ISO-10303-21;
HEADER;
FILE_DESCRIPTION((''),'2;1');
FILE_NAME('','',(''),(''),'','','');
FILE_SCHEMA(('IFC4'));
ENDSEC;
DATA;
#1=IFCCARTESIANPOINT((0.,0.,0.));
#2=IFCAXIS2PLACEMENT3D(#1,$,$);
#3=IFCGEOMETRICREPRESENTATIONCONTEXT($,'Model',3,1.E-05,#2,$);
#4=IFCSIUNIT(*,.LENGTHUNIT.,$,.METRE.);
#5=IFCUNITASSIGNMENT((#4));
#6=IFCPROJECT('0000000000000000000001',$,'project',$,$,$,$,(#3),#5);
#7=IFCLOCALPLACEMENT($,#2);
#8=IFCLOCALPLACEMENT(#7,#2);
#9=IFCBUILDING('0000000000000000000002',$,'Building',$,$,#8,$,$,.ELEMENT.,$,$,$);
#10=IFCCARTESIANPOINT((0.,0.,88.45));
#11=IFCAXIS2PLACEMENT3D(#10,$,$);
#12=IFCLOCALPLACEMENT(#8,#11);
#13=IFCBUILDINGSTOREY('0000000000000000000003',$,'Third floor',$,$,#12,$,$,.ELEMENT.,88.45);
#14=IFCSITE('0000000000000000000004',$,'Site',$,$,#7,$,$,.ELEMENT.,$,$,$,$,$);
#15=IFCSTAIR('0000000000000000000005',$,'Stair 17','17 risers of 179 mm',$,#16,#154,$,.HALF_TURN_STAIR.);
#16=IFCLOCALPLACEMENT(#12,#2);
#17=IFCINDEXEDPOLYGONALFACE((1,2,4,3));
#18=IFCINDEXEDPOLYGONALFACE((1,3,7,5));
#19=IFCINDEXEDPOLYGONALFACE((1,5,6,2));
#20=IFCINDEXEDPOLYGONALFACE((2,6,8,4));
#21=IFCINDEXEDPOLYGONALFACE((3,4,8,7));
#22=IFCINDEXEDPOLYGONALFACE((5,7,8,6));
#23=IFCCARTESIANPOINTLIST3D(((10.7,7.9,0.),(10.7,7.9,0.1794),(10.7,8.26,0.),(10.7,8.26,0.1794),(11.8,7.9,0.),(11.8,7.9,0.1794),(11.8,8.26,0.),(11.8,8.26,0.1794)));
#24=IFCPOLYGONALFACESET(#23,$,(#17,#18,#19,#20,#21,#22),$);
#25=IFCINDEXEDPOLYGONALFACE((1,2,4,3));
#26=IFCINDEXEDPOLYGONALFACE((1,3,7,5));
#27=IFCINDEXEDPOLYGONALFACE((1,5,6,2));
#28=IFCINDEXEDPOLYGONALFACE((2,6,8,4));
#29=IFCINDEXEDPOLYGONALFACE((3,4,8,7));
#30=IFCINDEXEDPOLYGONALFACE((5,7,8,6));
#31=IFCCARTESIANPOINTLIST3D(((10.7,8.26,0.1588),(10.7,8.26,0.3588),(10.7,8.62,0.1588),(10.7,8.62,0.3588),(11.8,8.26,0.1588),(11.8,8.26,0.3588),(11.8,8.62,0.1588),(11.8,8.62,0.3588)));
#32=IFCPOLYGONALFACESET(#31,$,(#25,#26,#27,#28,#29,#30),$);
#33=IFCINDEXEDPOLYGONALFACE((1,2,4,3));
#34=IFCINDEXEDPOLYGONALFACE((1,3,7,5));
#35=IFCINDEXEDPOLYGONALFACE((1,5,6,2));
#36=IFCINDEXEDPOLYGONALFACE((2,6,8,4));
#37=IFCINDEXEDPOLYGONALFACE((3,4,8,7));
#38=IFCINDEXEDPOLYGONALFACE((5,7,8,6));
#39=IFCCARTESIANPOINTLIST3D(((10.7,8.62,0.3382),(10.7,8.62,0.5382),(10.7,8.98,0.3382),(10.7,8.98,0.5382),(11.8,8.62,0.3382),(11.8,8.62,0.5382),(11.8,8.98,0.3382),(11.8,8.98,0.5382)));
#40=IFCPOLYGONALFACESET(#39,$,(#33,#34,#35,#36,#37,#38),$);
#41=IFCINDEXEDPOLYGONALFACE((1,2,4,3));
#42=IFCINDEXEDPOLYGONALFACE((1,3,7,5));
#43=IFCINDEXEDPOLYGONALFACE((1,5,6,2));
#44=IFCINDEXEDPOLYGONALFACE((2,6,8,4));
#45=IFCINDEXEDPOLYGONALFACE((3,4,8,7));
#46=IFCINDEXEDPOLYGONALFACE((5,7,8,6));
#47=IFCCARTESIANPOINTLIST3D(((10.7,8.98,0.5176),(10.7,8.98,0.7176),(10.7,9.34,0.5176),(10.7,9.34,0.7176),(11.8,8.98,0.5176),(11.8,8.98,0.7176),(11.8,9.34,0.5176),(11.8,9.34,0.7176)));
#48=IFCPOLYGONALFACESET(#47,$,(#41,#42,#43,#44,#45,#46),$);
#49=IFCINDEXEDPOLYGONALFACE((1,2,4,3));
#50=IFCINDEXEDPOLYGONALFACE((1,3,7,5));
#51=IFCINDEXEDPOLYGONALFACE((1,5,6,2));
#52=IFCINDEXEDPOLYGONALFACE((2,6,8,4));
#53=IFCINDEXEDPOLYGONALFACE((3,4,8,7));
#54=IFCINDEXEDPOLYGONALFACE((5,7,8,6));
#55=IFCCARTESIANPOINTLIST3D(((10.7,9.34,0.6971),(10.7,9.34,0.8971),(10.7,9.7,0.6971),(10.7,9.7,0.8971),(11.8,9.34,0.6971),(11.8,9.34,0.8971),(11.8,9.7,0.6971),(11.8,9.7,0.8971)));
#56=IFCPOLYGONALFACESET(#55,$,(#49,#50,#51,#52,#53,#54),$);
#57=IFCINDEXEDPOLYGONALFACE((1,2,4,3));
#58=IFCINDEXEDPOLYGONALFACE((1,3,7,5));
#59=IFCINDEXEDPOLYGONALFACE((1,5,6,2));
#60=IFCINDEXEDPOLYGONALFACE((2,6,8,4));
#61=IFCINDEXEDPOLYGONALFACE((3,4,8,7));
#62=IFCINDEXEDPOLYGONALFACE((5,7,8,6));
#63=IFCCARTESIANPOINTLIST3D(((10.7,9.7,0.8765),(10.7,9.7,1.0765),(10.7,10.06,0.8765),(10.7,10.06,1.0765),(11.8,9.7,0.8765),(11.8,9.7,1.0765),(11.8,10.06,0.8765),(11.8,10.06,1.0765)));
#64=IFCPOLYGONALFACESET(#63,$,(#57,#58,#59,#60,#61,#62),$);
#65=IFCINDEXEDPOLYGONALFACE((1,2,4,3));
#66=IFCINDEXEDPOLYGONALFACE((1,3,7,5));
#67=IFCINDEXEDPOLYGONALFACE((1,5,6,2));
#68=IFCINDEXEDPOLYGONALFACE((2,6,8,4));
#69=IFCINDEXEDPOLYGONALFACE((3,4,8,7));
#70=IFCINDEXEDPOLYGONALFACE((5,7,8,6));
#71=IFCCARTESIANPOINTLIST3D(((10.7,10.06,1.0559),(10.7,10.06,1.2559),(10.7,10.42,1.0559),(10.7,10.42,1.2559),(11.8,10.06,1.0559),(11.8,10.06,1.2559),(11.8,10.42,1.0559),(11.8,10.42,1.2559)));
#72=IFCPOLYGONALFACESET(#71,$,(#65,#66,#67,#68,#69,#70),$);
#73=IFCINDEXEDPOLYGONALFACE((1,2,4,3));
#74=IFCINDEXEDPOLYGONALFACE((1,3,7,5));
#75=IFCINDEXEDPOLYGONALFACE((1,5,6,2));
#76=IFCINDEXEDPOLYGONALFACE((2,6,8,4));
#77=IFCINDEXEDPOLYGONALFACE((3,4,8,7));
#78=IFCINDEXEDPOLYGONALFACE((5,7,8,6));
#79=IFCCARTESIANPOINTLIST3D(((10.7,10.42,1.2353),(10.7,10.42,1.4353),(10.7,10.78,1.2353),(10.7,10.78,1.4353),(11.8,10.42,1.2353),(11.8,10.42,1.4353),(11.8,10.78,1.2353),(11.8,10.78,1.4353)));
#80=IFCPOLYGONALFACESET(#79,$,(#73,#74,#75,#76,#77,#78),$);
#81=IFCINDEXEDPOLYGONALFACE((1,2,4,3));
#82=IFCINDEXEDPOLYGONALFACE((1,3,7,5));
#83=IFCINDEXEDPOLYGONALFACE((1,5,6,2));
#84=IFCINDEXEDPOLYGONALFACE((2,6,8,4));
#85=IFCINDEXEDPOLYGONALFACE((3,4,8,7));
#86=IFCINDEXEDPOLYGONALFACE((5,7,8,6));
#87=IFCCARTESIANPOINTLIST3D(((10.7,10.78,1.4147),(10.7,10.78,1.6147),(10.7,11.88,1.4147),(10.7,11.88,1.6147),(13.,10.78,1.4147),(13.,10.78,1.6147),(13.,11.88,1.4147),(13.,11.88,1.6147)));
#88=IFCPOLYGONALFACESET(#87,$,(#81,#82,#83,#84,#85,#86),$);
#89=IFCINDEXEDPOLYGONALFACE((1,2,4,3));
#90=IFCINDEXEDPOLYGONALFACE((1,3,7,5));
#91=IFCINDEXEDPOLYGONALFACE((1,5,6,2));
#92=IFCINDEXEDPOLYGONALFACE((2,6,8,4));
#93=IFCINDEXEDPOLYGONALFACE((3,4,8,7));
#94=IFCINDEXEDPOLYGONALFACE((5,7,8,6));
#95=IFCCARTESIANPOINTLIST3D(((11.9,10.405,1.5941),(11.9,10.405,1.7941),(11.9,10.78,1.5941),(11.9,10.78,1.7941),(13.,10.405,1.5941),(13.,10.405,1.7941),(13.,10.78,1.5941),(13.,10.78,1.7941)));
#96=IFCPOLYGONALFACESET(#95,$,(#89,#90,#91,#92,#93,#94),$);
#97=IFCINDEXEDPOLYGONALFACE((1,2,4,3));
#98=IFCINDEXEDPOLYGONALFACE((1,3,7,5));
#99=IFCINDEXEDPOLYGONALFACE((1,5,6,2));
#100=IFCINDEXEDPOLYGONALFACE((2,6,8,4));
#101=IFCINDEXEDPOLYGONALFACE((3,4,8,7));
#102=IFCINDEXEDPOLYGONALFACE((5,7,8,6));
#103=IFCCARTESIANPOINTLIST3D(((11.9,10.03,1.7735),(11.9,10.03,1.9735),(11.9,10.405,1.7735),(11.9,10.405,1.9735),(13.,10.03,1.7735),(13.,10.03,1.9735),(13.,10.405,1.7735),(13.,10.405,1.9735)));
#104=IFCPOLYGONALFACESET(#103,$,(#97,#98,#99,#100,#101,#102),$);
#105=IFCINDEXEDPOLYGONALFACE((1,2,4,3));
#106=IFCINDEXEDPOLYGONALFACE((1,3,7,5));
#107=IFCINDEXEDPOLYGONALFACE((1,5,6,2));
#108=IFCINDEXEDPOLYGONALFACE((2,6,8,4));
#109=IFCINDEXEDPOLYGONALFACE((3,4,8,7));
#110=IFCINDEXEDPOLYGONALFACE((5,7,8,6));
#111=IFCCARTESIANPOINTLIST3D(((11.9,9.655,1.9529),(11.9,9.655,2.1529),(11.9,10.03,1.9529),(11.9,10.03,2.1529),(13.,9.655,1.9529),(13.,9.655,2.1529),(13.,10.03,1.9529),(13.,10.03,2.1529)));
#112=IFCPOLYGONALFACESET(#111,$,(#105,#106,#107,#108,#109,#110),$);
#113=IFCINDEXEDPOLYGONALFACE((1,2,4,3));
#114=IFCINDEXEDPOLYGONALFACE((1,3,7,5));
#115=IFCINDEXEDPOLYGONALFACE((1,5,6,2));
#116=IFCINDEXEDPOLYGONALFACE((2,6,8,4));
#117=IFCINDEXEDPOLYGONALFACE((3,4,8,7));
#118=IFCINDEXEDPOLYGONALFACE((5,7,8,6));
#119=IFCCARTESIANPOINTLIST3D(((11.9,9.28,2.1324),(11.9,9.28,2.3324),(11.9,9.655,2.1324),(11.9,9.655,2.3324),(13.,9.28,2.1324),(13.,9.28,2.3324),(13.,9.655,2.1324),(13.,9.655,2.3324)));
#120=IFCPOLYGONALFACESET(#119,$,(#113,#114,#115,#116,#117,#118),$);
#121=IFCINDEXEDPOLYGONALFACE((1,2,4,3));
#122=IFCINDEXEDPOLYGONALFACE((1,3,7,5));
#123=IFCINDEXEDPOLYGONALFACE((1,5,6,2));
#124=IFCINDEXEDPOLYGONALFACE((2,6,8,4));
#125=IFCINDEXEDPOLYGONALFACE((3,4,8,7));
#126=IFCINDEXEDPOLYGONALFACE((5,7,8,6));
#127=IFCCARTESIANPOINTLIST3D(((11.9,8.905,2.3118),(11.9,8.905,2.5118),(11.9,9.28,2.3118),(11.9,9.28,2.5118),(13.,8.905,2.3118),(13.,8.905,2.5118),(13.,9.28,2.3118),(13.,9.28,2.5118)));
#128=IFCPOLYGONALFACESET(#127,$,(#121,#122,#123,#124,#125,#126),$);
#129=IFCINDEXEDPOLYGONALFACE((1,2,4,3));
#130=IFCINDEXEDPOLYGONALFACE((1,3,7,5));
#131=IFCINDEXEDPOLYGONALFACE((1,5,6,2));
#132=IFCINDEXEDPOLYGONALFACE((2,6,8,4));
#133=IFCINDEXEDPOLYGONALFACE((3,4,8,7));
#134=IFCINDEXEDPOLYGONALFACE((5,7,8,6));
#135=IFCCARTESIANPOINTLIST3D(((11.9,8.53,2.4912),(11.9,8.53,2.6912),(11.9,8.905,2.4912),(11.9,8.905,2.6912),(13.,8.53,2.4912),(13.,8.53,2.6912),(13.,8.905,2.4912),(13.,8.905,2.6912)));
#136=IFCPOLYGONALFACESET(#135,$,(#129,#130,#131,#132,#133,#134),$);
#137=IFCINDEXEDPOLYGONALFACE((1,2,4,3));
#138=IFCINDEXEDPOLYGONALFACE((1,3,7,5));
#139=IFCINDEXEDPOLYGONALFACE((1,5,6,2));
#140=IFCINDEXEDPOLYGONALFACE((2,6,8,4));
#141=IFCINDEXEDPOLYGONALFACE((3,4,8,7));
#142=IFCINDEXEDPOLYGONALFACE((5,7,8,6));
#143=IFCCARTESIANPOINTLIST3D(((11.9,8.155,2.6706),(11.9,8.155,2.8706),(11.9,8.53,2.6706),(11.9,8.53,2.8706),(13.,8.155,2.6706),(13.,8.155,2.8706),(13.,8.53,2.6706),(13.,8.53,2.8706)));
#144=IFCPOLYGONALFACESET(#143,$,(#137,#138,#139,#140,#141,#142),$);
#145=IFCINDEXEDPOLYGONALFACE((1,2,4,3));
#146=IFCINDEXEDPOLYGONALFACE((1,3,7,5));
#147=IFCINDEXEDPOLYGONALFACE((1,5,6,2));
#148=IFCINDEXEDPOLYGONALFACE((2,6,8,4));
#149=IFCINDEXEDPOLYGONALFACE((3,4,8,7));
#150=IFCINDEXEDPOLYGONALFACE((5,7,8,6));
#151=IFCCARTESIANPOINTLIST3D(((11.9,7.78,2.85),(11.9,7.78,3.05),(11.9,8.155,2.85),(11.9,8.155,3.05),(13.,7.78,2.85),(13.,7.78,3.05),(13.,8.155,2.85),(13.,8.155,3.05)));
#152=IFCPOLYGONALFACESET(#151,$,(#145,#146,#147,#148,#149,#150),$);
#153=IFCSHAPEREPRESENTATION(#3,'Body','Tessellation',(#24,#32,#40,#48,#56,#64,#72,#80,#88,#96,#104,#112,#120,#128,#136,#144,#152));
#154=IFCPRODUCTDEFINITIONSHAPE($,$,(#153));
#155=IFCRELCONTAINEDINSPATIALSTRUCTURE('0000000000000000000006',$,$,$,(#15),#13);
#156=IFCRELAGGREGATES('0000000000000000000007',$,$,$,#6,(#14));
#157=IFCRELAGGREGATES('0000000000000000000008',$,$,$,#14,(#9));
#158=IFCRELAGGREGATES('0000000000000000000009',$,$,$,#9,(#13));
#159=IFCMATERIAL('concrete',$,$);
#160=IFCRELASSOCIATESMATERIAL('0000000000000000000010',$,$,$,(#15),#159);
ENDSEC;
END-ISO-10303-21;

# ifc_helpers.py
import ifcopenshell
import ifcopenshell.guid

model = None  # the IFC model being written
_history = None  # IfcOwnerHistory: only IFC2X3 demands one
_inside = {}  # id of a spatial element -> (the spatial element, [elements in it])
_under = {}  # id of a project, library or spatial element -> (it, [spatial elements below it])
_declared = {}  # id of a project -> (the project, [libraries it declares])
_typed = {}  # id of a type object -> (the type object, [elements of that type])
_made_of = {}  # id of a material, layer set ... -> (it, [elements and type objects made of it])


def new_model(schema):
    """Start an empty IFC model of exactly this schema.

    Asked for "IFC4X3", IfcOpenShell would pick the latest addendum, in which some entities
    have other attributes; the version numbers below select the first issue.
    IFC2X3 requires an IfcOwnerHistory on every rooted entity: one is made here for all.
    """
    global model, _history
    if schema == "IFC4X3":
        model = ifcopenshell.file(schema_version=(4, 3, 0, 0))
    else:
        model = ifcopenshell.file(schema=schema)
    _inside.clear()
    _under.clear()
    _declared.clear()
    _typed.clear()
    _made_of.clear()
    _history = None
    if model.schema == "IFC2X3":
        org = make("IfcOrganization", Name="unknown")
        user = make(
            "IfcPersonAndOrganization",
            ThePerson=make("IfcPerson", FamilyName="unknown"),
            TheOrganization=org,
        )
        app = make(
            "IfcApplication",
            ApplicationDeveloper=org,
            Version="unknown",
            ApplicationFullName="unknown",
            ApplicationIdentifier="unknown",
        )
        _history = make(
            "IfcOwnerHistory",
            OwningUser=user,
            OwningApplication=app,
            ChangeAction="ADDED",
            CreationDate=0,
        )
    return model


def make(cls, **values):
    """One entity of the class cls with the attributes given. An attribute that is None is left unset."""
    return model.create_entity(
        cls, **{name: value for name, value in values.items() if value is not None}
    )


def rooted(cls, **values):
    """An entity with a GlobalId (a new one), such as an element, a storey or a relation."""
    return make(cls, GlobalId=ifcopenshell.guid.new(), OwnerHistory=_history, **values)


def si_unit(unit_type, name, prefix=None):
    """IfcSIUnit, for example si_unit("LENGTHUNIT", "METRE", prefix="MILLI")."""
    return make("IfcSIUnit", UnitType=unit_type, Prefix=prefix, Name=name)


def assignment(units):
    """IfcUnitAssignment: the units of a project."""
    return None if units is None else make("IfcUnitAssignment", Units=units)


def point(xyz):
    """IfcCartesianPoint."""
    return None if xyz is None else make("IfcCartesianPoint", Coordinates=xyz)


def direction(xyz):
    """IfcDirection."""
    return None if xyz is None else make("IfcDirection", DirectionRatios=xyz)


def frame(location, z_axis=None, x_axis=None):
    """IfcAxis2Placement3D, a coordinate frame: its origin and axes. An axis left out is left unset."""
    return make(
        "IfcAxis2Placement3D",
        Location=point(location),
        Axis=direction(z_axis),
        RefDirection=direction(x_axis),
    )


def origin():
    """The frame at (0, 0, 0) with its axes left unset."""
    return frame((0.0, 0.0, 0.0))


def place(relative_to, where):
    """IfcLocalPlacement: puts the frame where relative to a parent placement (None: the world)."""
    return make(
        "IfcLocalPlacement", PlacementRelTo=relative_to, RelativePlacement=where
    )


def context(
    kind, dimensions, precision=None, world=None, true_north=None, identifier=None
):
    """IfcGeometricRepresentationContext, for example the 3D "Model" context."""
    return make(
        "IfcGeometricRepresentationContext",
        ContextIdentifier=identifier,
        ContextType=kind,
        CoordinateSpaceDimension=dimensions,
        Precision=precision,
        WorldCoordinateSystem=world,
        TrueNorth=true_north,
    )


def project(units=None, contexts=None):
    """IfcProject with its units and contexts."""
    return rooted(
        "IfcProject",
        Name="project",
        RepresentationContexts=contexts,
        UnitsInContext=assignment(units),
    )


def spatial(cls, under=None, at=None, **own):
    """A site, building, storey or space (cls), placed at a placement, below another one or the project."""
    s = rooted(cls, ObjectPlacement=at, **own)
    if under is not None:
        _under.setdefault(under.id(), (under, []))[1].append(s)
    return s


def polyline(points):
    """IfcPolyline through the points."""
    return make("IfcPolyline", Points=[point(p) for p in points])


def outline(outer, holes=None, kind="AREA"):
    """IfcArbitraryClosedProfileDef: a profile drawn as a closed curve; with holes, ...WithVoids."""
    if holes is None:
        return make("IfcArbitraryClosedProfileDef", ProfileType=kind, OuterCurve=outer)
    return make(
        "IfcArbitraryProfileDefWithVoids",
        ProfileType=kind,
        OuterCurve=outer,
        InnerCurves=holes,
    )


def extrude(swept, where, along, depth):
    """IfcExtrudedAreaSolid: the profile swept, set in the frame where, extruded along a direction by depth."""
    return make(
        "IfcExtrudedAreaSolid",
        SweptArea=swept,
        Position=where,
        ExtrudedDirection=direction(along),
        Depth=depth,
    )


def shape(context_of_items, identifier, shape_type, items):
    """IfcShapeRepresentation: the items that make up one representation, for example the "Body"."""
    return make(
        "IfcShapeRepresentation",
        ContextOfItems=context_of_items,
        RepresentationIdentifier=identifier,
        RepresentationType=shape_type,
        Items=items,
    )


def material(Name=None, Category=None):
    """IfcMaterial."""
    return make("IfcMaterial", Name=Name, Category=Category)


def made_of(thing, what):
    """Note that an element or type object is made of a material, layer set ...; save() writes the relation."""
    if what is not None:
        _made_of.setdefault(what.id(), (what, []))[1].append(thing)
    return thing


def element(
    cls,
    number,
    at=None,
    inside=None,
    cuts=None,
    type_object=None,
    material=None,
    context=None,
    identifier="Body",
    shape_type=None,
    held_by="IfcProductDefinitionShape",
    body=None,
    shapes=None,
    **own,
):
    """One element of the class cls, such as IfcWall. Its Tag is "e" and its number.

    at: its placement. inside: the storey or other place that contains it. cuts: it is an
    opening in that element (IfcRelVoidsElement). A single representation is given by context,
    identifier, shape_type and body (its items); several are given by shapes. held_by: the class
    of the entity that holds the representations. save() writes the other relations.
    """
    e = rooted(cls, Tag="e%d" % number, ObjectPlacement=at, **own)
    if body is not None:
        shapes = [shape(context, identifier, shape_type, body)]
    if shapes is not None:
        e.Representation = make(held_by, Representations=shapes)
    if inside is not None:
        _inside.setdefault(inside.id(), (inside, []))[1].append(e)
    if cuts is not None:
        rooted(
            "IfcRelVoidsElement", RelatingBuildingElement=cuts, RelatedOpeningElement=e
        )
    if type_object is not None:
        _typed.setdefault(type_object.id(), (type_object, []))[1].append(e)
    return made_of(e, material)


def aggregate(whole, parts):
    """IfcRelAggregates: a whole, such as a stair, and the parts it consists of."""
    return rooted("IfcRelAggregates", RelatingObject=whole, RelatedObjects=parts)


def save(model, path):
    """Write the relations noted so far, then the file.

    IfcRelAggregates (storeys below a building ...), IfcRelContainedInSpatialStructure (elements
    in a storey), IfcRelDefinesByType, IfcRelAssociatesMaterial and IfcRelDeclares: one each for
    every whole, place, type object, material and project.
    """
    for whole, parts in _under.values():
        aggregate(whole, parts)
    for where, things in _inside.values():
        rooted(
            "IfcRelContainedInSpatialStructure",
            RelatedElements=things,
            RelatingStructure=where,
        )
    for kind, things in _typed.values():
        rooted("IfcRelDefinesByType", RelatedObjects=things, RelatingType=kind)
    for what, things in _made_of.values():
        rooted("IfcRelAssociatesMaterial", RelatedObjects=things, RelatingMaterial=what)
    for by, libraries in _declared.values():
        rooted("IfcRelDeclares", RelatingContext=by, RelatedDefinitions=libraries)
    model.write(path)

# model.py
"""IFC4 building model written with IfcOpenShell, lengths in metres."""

from ifc_helpers import new_model, si_unit, frame, origin, place, context, project, spatial, polyline, outline, extrude, material, element, save


model = new_model("IFC4")

# Units and contexts
model_context = context("Model", 3, precision=1e-05, world=origin())
ifc_project = project(units=[si_unit("LENGTHUNIT", "METRE")], contexts=[model_context])

# Site, building, storey
site_placement = place(None, origin())
site = spatial("IfcSite", under=ifc_project, at=site_placement, Name="Site", CompositionType="ELEMENT")
building_placement = place(site_placement, origin())
building = spatial("IfcBuilding", under=site, at=building_placement, Name="Building", CompositionType="ELEMENT")
storey_placement = place(building_placement, frame((0.0, 0.0, 88.45)))
storey = spatial("IfcBuildingStorey", under=building, at=storey_placement, Name="Third floor", CompositionType="ELEMENT", Elevation=88.45)

# Shared definitions
ifc_material = material(Name="concrete")

# Stair
stair_placement = place(storey_placement, frame((11.25, 7.9, 0.0), z_axis=(0.0, 0.0, 1.0), x_axis=(0.0, 1.0, 0.0)))
element("IfcStair", 1, at=stair_placement, inside=storey, material=ifc_material, Name="Stair 17", Description="17 risers of 179 mm", PredefinedType="HALF_TURN_STAIR", context=model_context, shape_type="SweptSolid", body=[
    extrude(outline(polyline([(0.0, -0.55), (0.36, -0.55), (0.36, 0.55), (0.0, 0.55), (0.0, -0.55)])), origin(), (0.0, 0.0, 1.0), 0.1794),
    extrude(outline(polyline([(0.36, -0.55), (0.72, -0.55), (0.72, 0.55), (0.36, 0.55), (0.36, -0.55)])), frame((0.0, 0.0, 0.1588)), (0.0, 0.0, 1.0), 0.2),
    extrude(outline(polyline([(0.72, -0.55), (1.08, -0.55), (1.08, 0.55), (0.72, 0.55), (0.72, -0.55)])), frame((0.0, 0.0, 0.3382)), (0.0, 0.0, 1.0), 0.2),
    extrude(outline(polyline([(1.08, -0.55), (1.44, -0.55), (1.44, 0.55), (1.08, 0.55), (1.08, -0.55)])), frame((0.0, 0.0, 0.5176)), (0.0, 0.0, 1.0), 0.2),
    extrude(outline(polyline([(1.44, -0.55), (1.8, -0.55), (1.8, 0.55), (1.44, 0.55), (1.44, -0.55)])), frame((0.0, 0.0, 0.6971)), (0.0, 0.0, 1.0), 0.2),
    extrude(outline(polyline([(1.8, -0.55), (2.16, -0.55), (2.16, 0.55), (1.8, 0.55), (1.8, -0.55)])), frame((0.0, 0.0, 0.8765)), (0.0, 0.0, 1.0), 0.2),
    extrude(outline(polyline([(2.16, -0.55), (2.52, -0.55), (2.52, 0.55), (2.16, 0.55), (2.16, -0.55)])), frame((0.0, 0.0, 1.0559)), (0.0, 0.0, 1.0), 0.2),
    extrude(outline(polyline([(2.52, -0.55), (2.88, -0.55), (2.88, 0.55), (2.52, 0.55), (2.52, -0.55)])), frame((0.0, 0.0, 1.2353)), (0.0, 0.0, 1.0), 0.2),
    extrude(outline(polyline([(2.88, -1.75), (3.98, -1.75), (3.98, 0.55), (2.88, 0.55), (2.88, -1.75)])), frame((0.0, 0.0, 1.4147)), (0.0, 0.0, 1.0), 0.2),
    extrude(outline(polyline([(2.505, -1.75), (2.88, -1.75), (2.88, -0.65), (2.505, -0.65), (2.505, -1.75)])), frame((0.0, 0.0, 1.5941)), (0.0, 0.0, 1.0), 0.2),
    extrude(outline(polyline([(2.13, -1.75), (2.505, -1.75), (2.505, -0.65), (2.13, -0.65), (2.13, -1.75)])), frame((0.0, 0.0, 1.7735)), (0.0, 0.0, 1.0), 0.2),
    extrude(outline(polyline([(1.755, -1.75), (2.13, -1.75), (2.13, -0.65), (1.755, -0.65), (1.755, -1.75)])), frame((0.0, 0.0, 1.9529)), (0.0, 0.0, 1.0), 0.2),
    extrude(outline(polyline([(1.38, -1.75), (1.755, -1.75), (1.755, -0.65), (1.38, -0.65), (1.38, -1.75)])), frame((0.0, 0.0, 2.1324)), (0.0, 0.0, 1.0), 0.2),
    extrude(outline(polyline([(1.005, -1.75), (1.38, -1.75), (1.38, -0.65), (1.005, -0.65), (1.005, -1.75)])), frame((0.0, 0.0, 2.3118)), (0.0, 0.0, 1.0), 0.2),
    extrude(outline(polyline([(0.63, -1.75), (1.005, -1.75), (1.005, -0.65), (0.63, -0.65), (0.63, -1.75)])), frame((0.0, 0.0, 2.4912)), (0.0, 0.0, 1.0), 0.2),
    extrude(outline(polyline([(0.255, -1.75), (0.63, -1.75), (0.63, -0.65), (0.255, -0.65), (0.255, -1.75)])), frame((0.0, 0.0, 2.6706)), (0.0, 0.0, 1.0), 0.2),
    extrude(outline(polyline([(-0.12, -1.75), (0.255, -1.75), (0.255, -0.65), (-0.12, -0.65), (-0.12, -1.75)])), frame((0.0, 0.0, 2.85)), (0.0, 0.0, 1.0), 0.2),
])

save(model, "model.ifc")
